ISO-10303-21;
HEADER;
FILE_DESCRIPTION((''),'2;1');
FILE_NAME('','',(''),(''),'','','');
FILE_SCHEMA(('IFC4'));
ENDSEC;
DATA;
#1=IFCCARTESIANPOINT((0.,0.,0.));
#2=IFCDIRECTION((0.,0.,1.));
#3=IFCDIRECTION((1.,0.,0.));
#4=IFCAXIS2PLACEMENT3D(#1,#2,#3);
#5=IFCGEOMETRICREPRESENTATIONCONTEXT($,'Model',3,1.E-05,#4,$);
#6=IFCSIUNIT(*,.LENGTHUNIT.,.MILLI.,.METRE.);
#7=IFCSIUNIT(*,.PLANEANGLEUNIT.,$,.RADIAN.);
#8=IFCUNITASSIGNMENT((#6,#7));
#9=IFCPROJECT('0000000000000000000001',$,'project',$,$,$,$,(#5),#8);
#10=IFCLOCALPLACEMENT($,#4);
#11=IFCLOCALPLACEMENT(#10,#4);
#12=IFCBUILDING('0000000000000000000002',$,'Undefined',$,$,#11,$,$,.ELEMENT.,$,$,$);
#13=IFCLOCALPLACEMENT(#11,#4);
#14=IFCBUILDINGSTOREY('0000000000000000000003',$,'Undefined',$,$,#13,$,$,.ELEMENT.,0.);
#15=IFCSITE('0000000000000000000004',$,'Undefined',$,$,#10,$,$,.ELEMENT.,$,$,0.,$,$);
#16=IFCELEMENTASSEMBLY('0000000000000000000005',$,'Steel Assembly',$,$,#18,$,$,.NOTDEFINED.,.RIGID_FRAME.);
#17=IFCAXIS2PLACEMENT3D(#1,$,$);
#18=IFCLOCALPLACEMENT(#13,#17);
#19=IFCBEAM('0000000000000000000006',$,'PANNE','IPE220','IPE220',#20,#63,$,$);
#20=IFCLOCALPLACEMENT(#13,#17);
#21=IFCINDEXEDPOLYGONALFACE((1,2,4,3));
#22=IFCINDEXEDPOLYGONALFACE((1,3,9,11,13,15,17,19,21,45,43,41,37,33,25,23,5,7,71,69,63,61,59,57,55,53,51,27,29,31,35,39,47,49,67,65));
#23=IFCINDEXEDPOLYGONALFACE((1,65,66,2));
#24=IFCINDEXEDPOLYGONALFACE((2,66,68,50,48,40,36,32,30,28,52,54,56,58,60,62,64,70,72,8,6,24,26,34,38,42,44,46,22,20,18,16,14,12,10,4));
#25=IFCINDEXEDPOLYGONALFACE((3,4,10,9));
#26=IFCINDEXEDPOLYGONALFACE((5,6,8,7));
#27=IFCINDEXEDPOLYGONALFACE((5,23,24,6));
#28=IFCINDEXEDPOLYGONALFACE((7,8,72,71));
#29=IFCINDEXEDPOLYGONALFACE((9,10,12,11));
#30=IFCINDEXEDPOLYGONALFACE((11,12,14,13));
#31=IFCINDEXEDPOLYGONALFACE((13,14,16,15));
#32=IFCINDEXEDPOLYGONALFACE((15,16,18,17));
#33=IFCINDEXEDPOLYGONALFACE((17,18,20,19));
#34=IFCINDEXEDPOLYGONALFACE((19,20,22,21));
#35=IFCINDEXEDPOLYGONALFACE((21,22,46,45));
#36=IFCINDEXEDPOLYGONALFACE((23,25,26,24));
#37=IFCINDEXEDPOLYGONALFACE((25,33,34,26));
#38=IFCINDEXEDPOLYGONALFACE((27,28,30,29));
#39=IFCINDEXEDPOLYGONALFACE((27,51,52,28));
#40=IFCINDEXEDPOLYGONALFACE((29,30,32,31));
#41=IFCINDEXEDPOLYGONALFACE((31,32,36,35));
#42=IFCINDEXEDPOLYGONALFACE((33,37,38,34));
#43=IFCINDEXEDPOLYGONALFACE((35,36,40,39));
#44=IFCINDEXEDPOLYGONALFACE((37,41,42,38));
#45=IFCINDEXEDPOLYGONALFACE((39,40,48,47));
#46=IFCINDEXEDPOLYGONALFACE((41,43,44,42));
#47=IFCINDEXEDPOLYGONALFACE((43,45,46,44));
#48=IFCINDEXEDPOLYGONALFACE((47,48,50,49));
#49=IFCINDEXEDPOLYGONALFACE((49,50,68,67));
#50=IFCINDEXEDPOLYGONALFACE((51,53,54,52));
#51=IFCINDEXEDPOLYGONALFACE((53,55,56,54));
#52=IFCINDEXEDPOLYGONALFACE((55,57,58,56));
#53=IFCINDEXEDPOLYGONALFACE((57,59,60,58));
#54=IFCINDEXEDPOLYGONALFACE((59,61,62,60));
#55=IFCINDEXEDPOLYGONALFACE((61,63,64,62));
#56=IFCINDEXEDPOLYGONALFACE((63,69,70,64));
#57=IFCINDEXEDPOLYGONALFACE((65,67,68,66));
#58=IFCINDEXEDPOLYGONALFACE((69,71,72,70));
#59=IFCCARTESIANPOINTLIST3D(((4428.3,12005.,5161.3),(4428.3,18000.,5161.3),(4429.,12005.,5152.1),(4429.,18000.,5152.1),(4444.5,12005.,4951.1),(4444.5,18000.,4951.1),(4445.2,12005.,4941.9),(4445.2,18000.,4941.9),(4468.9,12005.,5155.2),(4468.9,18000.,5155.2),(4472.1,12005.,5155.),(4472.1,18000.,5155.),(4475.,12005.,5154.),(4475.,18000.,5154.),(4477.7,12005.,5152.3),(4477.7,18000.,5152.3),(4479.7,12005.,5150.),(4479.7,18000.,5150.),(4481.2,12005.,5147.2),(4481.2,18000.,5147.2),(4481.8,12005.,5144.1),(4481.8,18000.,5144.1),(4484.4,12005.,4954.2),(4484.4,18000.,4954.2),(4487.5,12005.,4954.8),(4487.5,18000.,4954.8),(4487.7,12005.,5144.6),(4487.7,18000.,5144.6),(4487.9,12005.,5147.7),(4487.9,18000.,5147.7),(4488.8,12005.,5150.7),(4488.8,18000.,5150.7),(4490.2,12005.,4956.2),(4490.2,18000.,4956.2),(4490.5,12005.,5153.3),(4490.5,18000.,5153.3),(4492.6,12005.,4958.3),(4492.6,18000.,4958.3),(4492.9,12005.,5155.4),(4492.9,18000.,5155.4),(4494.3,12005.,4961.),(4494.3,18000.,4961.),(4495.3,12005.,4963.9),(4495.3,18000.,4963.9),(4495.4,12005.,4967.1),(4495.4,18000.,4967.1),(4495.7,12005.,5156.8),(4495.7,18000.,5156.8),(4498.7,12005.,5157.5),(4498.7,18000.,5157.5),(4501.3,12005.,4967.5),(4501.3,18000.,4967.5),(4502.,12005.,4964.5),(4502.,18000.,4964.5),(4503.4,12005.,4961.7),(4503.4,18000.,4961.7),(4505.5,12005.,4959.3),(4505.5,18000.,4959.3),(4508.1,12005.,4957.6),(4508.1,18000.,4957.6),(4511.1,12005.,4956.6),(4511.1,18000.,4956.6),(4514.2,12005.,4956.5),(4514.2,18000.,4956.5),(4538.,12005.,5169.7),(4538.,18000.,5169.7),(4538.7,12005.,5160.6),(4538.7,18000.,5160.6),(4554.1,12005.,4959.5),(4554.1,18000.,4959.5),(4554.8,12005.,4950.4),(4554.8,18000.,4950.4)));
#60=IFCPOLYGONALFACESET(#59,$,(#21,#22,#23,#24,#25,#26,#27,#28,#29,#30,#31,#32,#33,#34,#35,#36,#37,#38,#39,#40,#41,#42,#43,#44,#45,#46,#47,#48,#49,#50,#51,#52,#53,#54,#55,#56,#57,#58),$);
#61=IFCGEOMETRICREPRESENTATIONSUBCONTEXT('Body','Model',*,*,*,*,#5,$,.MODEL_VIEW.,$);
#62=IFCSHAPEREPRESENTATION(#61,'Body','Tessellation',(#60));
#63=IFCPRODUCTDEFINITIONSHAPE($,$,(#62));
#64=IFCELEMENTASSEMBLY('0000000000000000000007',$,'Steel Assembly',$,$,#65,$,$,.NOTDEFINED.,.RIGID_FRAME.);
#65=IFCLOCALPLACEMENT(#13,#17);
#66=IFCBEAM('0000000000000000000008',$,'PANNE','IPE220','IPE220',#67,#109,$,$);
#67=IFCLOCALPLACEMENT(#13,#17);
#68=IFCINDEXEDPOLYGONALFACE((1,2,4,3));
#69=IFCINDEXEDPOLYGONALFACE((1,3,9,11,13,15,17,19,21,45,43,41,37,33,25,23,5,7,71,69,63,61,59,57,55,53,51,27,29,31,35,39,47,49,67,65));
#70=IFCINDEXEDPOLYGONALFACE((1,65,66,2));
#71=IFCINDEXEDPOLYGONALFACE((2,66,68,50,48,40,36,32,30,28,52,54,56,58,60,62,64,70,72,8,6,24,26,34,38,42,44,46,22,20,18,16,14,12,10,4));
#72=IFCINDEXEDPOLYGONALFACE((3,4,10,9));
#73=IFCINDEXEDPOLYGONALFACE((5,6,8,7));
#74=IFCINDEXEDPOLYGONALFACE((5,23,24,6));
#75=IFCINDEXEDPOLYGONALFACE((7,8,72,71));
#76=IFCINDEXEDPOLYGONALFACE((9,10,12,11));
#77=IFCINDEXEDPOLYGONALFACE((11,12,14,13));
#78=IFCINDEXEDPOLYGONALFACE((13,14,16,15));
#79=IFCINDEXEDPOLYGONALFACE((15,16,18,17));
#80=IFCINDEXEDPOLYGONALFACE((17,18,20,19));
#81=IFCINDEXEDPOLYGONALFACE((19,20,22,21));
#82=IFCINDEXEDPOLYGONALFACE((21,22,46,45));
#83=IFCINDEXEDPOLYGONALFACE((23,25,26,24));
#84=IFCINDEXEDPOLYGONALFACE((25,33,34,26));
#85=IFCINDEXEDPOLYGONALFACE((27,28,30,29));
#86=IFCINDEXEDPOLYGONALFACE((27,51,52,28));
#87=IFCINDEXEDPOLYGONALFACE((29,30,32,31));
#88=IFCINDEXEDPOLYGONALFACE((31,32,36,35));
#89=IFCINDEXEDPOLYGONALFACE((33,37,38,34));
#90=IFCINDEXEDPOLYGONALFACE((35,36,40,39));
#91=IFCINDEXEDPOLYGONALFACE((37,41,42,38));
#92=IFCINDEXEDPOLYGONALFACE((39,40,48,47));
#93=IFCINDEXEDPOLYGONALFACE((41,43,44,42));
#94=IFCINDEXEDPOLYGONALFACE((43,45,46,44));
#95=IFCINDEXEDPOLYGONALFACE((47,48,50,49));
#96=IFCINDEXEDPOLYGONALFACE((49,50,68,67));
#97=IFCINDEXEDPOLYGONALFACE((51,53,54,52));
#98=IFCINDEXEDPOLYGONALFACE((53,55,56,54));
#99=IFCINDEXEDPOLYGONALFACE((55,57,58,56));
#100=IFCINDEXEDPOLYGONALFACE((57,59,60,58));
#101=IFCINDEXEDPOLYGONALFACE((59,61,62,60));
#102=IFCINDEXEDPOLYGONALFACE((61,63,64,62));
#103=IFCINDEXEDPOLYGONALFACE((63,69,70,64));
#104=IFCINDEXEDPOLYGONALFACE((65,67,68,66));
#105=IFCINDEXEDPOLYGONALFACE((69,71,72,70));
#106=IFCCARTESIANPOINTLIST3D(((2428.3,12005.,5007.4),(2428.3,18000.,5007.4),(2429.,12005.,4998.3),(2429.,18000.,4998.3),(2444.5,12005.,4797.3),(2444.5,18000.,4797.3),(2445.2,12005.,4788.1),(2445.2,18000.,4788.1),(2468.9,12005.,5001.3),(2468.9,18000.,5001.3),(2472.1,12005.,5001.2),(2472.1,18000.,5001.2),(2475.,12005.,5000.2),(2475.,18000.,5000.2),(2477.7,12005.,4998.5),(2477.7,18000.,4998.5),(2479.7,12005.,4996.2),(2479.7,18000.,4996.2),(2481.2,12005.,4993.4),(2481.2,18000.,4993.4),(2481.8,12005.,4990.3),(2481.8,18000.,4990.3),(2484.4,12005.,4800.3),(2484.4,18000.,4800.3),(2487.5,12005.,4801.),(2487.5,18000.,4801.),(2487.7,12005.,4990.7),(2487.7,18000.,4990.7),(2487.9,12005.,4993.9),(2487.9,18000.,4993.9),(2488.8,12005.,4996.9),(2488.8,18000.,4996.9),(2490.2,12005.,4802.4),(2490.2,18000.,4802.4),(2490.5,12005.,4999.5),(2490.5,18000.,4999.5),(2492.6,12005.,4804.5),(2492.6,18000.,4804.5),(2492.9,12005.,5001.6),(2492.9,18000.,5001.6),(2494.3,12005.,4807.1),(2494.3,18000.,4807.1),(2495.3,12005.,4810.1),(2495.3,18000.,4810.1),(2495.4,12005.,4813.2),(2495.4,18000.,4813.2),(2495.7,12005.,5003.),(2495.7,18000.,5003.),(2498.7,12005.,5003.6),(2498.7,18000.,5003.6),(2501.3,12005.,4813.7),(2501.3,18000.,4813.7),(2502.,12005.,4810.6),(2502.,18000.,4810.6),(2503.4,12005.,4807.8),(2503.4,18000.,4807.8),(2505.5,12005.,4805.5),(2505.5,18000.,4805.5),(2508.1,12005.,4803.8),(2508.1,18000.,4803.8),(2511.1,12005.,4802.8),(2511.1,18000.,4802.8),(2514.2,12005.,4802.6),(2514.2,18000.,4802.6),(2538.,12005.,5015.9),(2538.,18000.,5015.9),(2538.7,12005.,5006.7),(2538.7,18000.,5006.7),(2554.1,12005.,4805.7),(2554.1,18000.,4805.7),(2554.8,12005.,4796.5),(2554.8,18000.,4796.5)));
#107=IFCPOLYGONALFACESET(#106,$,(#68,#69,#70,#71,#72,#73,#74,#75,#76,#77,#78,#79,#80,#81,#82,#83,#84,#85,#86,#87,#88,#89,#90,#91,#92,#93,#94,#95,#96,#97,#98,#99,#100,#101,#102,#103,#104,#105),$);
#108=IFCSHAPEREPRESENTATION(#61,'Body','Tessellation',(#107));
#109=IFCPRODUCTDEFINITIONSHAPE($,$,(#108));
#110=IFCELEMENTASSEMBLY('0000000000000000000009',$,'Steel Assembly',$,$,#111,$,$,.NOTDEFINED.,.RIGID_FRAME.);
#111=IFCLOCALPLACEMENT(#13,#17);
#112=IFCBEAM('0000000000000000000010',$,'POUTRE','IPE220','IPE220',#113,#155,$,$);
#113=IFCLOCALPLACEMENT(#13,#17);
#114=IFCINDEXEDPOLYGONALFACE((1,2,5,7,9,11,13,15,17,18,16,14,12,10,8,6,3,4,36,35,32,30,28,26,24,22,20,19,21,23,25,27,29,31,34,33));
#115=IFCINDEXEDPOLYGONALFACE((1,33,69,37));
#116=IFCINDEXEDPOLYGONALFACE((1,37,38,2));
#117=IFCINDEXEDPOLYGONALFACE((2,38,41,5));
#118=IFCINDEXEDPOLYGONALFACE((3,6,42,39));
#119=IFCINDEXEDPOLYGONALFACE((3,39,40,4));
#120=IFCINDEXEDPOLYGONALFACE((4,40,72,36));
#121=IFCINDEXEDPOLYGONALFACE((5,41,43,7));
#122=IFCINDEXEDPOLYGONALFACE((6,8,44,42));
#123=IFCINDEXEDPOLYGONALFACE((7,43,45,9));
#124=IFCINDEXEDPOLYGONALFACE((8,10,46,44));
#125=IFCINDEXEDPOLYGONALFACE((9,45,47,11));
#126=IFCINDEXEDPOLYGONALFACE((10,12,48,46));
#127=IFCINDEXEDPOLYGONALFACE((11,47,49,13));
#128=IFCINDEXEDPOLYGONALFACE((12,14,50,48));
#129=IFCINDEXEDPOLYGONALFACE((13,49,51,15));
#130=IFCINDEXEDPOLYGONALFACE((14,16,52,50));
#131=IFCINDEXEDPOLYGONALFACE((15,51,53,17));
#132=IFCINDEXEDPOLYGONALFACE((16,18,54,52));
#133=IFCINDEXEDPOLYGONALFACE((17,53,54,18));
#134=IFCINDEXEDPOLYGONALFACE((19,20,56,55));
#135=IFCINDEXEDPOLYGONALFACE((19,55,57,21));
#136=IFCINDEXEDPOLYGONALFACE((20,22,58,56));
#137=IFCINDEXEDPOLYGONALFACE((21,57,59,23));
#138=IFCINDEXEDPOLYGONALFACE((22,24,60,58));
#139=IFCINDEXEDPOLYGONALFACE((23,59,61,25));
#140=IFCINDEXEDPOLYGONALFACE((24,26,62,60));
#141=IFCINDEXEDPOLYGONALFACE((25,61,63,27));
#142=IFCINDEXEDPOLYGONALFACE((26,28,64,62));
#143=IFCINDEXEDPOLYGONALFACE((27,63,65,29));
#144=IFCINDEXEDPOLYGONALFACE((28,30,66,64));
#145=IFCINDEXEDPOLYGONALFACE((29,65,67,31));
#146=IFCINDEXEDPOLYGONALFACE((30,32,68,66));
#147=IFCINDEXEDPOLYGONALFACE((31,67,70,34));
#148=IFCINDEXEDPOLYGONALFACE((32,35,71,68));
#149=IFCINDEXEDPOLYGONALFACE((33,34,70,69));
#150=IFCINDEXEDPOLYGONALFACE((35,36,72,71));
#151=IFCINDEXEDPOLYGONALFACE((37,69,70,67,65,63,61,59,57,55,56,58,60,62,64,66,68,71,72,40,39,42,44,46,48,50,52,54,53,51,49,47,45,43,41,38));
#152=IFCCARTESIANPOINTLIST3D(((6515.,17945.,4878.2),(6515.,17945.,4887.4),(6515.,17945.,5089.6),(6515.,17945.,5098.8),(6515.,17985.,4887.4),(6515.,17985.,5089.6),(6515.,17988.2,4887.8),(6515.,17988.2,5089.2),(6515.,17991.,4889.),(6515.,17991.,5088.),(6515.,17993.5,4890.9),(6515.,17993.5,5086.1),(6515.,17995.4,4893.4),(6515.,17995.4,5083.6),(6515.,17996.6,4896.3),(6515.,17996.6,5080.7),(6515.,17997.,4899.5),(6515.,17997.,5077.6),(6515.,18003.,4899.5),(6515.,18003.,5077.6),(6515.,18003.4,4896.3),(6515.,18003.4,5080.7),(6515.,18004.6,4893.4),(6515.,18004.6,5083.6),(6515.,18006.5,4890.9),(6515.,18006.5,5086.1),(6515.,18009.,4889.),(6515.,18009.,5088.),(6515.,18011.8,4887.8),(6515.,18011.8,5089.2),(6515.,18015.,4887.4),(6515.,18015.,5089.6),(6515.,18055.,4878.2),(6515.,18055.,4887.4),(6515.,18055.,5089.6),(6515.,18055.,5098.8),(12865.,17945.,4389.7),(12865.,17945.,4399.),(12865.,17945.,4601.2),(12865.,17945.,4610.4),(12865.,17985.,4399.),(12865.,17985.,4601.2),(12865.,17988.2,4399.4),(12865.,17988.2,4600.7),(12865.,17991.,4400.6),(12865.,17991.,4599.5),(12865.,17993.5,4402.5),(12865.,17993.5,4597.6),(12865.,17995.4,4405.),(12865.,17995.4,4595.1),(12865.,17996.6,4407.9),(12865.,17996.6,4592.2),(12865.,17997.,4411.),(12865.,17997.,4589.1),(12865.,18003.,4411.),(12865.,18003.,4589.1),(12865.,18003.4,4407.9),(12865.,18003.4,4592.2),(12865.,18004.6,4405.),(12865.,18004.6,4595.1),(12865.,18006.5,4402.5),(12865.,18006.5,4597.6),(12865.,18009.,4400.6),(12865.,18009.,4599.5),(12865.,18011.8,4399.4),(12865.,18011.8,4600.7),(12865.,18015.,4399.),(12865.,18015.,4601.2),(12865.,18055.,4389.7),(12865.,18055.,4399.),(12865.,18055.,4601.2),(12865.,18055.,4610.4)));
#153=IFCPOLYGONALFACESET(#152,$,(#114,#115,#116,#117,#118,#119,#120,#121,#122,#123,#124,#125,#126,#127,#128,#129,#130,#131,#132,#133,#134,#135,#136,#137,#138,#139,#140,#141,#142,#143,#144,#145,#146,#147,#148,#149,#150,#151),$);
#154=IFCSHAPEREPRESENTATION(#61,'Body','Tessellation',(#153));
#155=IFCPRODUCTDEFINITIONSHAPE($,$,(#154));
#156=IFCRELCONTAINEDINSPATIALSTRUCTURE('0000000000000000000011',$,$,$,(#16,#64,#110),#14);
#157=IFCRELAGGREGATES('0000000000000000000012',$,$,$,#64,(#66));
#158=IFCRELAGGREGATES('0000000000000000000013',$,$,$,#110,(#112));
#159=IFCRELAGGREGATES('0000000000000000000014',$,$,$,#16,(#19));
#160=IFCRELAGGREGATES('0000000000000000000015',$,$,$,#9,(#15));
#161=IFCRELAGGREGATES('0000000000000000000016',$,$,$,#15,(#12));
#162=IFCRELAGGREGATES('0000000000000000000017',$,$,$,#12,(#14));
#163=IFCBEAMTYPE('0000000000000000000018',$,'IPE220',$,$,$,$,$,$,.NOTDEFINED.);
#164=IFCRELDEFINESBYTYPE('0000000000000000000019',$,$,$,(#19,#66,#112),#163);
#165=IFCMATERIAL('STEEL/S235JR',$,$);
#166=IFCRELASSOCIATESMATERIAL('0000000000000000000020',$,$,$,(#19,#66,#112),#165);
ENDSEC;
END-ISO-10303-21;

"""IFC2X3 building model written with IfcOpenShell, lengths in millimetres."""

from ifc_helpers import new_model, si_unit, frame, origin_with_axes, origin_2d_with_axis, place, context, subcontext, project, spatial, i_section, extrude, clip, halfspace, material, type_object, element, aggregate, save


model = new_model("IFC2X3")

# Units and contexts
model_context = context("Model", 3, precision=1e-05, world=origin_with_axes())
body_context = subcontext(model_context, "Body", "Model", "MODEL_VIEW")
ifc_project = project(units=[si_unit("LENGTHUNIT", "METRE", prefix="MILLI"), si_unit("PLANEANGLEUNIT", "RADIAN")], contexts=[model_context])

# Site, building, storey
site_placement = place(None, origin_with_axes())
site = spatial("IfcSite", under=ifc_project, at=site_placement, Name="Undefined", CompositionType="ELEMENT", RefElevation=0.0)
building_placement = place(site_placement, origin_with_axes())
building = spatial("IfcBuilding", under=site, at=building_placement, Name="Undefined", CompositionType="ELEMENT")
storey_placement = place(building_placement, origin_with_axes())
storey = spatial("IfcBuildingStorey", under=building, at=storey_placement, Name="Undefined", CompositionType="ELEMENT", Elevation=0.0)

# Element assemblies, beams
ifc_material_1 = material(Name="STEEL/S235JR")
beam_type_1 = type_object("IfcBeamType", Name="IPE220", PredefinedType="NOTDEFINED")
assembly_1_placement = place(storey_placement, origin_with_axes())
assembly_1 = element("IfcElementAssembly", 1, at=assembly_1_placement, inside=storey, Name="Steel Assembly", AssemblyPlace="NOTDEFINED", PredefinedType="RIGID_FRAME")
beam_1_placement = place(assembly_1_placement, frame((4491.6, 18000.0, 5055.8), z_axis=(-0.076696, 0.0, 0.997054), x_axis=(0.0, -1.0, 0.0)))
beam_1 = element("IfcBeam", 2, at=beam_1_placement, type_object=beam_type_1, material=ifc_material_1, Name="PANNE", Description="IPE220", ObjectType="IPE220", context=body_context, shape_type="Clipping", body=[
    clip(extrude(i_section(OverallWidth=110.0, OverallDepth=220.0, WebThickness=5.9, FlangeThickness=9.2, FilletRadius=12.0, at=origin_2d_with_axis()), frame((5995.0, 0.0, 0.0), z_axis=(-1.0, 0.0, 0.0), x_axis=(0.0, -1.0, 0.0)), (0.0, 0.0, 1.0), 5995.0), halfspace(frame((5995.0, 0.0, 0.0), z_axis=(1.0, 0.0, 0.0), x_axis=(0.0, -1.0, 0.0)), False)),
])
assembly_2_placement = place(storey_placement, origin_with_axes())
assembly_2 = element("IfcElementAssembly", 3, at=assembly_2_placement, inside=storey, Name="Steel Assembly", AssemblyPlace="NOTDEFINED", PredefinedType="RIGID_FRAME")
beam_2_placement = place(assembly_2_placement, frame((2491.6, 18000.0, 4902.0), z_axis=(-0.076696, 0.0, 0.997054), x_axis=(0.0, -1.0, 0.0)))
beam_2 = element("IfcBeam", 4, at=beam_2_placement, type_object=beam_type_1, material=ifc_material_1, Name="PANNE", Description="IPE220", ObjectType="IPE220", context=body_context, shape_type="Clipping", body=[
    clip(extrude(i_section(OverallWidth=110.0, OverallDepth=220.0, WebThickness=5.9, FlangeThickness=9.2, FilletRadius=12.0, at=origin_2d_with_axis()), frame((5995.0, 0.0, 0.0), z_axis=(-1.0, 0.0, 0.0), x_axis=(0.0, -1.0, 0.0)), (0.0, 0.0, 1.0), 5995.0), halfspace(frame((5995.0, 0.0, 0.0), z_axis=(1.0, 0.0, 0.0), x_axis=(0.0, -1.0, 0.0)), False)),
])
aggregate(assembly_2, [beam_2])
assembly_3_placement = place(storey_placement, origin_with_axes())
assembly_3 = element("IfcElementAssembly", 5, at=assembly_3_placement, inside=storey, Name="Steel Assembly", AssemblyPlace="NOTDEFINED", PredefinedType="RIGID_FRAME")
beam_3_placement = place(assembly_3_placement, frame((6491.6, 18000.0, 4990.3), z_axis=(0.076696, 0.0, 0.997054), x_axis=(0.997054, 0.0, -0.076696)))
beam_3 = element("IfcBeam", 6, at=beam_3_placement, type_object=beam_type_1, material=ifc_material_1, Name="POUTRE", Description="IPE220", ObjectType="IPE220", context=body_context, shape_type="Clipping", body=[
    clip(clip(extrude(i_section(OverallWidth=110.0, OverallDepth=220.0, WebThickness=5.9, FlangeThickness=9.2, FilletRadius=12.0, at=origin_2d_with_axis()), frame((6409.4, 0.0, 0.0), z_axis=(-1.0, 0.0, 0.0), x_axis=(0.0, -1.0, 0.0)), (0.0, 0.0, 1.0), 6402.9), halfspace(frame((6400.7, 0.0, -110.0), z_axis=(-0.997054, 0.0, -0.076696), x_axis=(-0.076696, 0.0, 0.997054)), True)), halfspace(frame((15.0, 0.0, 111.2), z_axis=(-0.997054, 0.0, -0.076696), x_axis=(0.0, -1.0, 0.0)), False)),
])
aggregate(assembly_3, [beam_3])

aggregate(assembly_1, [beam_1])

save(model, "model.ifc")
